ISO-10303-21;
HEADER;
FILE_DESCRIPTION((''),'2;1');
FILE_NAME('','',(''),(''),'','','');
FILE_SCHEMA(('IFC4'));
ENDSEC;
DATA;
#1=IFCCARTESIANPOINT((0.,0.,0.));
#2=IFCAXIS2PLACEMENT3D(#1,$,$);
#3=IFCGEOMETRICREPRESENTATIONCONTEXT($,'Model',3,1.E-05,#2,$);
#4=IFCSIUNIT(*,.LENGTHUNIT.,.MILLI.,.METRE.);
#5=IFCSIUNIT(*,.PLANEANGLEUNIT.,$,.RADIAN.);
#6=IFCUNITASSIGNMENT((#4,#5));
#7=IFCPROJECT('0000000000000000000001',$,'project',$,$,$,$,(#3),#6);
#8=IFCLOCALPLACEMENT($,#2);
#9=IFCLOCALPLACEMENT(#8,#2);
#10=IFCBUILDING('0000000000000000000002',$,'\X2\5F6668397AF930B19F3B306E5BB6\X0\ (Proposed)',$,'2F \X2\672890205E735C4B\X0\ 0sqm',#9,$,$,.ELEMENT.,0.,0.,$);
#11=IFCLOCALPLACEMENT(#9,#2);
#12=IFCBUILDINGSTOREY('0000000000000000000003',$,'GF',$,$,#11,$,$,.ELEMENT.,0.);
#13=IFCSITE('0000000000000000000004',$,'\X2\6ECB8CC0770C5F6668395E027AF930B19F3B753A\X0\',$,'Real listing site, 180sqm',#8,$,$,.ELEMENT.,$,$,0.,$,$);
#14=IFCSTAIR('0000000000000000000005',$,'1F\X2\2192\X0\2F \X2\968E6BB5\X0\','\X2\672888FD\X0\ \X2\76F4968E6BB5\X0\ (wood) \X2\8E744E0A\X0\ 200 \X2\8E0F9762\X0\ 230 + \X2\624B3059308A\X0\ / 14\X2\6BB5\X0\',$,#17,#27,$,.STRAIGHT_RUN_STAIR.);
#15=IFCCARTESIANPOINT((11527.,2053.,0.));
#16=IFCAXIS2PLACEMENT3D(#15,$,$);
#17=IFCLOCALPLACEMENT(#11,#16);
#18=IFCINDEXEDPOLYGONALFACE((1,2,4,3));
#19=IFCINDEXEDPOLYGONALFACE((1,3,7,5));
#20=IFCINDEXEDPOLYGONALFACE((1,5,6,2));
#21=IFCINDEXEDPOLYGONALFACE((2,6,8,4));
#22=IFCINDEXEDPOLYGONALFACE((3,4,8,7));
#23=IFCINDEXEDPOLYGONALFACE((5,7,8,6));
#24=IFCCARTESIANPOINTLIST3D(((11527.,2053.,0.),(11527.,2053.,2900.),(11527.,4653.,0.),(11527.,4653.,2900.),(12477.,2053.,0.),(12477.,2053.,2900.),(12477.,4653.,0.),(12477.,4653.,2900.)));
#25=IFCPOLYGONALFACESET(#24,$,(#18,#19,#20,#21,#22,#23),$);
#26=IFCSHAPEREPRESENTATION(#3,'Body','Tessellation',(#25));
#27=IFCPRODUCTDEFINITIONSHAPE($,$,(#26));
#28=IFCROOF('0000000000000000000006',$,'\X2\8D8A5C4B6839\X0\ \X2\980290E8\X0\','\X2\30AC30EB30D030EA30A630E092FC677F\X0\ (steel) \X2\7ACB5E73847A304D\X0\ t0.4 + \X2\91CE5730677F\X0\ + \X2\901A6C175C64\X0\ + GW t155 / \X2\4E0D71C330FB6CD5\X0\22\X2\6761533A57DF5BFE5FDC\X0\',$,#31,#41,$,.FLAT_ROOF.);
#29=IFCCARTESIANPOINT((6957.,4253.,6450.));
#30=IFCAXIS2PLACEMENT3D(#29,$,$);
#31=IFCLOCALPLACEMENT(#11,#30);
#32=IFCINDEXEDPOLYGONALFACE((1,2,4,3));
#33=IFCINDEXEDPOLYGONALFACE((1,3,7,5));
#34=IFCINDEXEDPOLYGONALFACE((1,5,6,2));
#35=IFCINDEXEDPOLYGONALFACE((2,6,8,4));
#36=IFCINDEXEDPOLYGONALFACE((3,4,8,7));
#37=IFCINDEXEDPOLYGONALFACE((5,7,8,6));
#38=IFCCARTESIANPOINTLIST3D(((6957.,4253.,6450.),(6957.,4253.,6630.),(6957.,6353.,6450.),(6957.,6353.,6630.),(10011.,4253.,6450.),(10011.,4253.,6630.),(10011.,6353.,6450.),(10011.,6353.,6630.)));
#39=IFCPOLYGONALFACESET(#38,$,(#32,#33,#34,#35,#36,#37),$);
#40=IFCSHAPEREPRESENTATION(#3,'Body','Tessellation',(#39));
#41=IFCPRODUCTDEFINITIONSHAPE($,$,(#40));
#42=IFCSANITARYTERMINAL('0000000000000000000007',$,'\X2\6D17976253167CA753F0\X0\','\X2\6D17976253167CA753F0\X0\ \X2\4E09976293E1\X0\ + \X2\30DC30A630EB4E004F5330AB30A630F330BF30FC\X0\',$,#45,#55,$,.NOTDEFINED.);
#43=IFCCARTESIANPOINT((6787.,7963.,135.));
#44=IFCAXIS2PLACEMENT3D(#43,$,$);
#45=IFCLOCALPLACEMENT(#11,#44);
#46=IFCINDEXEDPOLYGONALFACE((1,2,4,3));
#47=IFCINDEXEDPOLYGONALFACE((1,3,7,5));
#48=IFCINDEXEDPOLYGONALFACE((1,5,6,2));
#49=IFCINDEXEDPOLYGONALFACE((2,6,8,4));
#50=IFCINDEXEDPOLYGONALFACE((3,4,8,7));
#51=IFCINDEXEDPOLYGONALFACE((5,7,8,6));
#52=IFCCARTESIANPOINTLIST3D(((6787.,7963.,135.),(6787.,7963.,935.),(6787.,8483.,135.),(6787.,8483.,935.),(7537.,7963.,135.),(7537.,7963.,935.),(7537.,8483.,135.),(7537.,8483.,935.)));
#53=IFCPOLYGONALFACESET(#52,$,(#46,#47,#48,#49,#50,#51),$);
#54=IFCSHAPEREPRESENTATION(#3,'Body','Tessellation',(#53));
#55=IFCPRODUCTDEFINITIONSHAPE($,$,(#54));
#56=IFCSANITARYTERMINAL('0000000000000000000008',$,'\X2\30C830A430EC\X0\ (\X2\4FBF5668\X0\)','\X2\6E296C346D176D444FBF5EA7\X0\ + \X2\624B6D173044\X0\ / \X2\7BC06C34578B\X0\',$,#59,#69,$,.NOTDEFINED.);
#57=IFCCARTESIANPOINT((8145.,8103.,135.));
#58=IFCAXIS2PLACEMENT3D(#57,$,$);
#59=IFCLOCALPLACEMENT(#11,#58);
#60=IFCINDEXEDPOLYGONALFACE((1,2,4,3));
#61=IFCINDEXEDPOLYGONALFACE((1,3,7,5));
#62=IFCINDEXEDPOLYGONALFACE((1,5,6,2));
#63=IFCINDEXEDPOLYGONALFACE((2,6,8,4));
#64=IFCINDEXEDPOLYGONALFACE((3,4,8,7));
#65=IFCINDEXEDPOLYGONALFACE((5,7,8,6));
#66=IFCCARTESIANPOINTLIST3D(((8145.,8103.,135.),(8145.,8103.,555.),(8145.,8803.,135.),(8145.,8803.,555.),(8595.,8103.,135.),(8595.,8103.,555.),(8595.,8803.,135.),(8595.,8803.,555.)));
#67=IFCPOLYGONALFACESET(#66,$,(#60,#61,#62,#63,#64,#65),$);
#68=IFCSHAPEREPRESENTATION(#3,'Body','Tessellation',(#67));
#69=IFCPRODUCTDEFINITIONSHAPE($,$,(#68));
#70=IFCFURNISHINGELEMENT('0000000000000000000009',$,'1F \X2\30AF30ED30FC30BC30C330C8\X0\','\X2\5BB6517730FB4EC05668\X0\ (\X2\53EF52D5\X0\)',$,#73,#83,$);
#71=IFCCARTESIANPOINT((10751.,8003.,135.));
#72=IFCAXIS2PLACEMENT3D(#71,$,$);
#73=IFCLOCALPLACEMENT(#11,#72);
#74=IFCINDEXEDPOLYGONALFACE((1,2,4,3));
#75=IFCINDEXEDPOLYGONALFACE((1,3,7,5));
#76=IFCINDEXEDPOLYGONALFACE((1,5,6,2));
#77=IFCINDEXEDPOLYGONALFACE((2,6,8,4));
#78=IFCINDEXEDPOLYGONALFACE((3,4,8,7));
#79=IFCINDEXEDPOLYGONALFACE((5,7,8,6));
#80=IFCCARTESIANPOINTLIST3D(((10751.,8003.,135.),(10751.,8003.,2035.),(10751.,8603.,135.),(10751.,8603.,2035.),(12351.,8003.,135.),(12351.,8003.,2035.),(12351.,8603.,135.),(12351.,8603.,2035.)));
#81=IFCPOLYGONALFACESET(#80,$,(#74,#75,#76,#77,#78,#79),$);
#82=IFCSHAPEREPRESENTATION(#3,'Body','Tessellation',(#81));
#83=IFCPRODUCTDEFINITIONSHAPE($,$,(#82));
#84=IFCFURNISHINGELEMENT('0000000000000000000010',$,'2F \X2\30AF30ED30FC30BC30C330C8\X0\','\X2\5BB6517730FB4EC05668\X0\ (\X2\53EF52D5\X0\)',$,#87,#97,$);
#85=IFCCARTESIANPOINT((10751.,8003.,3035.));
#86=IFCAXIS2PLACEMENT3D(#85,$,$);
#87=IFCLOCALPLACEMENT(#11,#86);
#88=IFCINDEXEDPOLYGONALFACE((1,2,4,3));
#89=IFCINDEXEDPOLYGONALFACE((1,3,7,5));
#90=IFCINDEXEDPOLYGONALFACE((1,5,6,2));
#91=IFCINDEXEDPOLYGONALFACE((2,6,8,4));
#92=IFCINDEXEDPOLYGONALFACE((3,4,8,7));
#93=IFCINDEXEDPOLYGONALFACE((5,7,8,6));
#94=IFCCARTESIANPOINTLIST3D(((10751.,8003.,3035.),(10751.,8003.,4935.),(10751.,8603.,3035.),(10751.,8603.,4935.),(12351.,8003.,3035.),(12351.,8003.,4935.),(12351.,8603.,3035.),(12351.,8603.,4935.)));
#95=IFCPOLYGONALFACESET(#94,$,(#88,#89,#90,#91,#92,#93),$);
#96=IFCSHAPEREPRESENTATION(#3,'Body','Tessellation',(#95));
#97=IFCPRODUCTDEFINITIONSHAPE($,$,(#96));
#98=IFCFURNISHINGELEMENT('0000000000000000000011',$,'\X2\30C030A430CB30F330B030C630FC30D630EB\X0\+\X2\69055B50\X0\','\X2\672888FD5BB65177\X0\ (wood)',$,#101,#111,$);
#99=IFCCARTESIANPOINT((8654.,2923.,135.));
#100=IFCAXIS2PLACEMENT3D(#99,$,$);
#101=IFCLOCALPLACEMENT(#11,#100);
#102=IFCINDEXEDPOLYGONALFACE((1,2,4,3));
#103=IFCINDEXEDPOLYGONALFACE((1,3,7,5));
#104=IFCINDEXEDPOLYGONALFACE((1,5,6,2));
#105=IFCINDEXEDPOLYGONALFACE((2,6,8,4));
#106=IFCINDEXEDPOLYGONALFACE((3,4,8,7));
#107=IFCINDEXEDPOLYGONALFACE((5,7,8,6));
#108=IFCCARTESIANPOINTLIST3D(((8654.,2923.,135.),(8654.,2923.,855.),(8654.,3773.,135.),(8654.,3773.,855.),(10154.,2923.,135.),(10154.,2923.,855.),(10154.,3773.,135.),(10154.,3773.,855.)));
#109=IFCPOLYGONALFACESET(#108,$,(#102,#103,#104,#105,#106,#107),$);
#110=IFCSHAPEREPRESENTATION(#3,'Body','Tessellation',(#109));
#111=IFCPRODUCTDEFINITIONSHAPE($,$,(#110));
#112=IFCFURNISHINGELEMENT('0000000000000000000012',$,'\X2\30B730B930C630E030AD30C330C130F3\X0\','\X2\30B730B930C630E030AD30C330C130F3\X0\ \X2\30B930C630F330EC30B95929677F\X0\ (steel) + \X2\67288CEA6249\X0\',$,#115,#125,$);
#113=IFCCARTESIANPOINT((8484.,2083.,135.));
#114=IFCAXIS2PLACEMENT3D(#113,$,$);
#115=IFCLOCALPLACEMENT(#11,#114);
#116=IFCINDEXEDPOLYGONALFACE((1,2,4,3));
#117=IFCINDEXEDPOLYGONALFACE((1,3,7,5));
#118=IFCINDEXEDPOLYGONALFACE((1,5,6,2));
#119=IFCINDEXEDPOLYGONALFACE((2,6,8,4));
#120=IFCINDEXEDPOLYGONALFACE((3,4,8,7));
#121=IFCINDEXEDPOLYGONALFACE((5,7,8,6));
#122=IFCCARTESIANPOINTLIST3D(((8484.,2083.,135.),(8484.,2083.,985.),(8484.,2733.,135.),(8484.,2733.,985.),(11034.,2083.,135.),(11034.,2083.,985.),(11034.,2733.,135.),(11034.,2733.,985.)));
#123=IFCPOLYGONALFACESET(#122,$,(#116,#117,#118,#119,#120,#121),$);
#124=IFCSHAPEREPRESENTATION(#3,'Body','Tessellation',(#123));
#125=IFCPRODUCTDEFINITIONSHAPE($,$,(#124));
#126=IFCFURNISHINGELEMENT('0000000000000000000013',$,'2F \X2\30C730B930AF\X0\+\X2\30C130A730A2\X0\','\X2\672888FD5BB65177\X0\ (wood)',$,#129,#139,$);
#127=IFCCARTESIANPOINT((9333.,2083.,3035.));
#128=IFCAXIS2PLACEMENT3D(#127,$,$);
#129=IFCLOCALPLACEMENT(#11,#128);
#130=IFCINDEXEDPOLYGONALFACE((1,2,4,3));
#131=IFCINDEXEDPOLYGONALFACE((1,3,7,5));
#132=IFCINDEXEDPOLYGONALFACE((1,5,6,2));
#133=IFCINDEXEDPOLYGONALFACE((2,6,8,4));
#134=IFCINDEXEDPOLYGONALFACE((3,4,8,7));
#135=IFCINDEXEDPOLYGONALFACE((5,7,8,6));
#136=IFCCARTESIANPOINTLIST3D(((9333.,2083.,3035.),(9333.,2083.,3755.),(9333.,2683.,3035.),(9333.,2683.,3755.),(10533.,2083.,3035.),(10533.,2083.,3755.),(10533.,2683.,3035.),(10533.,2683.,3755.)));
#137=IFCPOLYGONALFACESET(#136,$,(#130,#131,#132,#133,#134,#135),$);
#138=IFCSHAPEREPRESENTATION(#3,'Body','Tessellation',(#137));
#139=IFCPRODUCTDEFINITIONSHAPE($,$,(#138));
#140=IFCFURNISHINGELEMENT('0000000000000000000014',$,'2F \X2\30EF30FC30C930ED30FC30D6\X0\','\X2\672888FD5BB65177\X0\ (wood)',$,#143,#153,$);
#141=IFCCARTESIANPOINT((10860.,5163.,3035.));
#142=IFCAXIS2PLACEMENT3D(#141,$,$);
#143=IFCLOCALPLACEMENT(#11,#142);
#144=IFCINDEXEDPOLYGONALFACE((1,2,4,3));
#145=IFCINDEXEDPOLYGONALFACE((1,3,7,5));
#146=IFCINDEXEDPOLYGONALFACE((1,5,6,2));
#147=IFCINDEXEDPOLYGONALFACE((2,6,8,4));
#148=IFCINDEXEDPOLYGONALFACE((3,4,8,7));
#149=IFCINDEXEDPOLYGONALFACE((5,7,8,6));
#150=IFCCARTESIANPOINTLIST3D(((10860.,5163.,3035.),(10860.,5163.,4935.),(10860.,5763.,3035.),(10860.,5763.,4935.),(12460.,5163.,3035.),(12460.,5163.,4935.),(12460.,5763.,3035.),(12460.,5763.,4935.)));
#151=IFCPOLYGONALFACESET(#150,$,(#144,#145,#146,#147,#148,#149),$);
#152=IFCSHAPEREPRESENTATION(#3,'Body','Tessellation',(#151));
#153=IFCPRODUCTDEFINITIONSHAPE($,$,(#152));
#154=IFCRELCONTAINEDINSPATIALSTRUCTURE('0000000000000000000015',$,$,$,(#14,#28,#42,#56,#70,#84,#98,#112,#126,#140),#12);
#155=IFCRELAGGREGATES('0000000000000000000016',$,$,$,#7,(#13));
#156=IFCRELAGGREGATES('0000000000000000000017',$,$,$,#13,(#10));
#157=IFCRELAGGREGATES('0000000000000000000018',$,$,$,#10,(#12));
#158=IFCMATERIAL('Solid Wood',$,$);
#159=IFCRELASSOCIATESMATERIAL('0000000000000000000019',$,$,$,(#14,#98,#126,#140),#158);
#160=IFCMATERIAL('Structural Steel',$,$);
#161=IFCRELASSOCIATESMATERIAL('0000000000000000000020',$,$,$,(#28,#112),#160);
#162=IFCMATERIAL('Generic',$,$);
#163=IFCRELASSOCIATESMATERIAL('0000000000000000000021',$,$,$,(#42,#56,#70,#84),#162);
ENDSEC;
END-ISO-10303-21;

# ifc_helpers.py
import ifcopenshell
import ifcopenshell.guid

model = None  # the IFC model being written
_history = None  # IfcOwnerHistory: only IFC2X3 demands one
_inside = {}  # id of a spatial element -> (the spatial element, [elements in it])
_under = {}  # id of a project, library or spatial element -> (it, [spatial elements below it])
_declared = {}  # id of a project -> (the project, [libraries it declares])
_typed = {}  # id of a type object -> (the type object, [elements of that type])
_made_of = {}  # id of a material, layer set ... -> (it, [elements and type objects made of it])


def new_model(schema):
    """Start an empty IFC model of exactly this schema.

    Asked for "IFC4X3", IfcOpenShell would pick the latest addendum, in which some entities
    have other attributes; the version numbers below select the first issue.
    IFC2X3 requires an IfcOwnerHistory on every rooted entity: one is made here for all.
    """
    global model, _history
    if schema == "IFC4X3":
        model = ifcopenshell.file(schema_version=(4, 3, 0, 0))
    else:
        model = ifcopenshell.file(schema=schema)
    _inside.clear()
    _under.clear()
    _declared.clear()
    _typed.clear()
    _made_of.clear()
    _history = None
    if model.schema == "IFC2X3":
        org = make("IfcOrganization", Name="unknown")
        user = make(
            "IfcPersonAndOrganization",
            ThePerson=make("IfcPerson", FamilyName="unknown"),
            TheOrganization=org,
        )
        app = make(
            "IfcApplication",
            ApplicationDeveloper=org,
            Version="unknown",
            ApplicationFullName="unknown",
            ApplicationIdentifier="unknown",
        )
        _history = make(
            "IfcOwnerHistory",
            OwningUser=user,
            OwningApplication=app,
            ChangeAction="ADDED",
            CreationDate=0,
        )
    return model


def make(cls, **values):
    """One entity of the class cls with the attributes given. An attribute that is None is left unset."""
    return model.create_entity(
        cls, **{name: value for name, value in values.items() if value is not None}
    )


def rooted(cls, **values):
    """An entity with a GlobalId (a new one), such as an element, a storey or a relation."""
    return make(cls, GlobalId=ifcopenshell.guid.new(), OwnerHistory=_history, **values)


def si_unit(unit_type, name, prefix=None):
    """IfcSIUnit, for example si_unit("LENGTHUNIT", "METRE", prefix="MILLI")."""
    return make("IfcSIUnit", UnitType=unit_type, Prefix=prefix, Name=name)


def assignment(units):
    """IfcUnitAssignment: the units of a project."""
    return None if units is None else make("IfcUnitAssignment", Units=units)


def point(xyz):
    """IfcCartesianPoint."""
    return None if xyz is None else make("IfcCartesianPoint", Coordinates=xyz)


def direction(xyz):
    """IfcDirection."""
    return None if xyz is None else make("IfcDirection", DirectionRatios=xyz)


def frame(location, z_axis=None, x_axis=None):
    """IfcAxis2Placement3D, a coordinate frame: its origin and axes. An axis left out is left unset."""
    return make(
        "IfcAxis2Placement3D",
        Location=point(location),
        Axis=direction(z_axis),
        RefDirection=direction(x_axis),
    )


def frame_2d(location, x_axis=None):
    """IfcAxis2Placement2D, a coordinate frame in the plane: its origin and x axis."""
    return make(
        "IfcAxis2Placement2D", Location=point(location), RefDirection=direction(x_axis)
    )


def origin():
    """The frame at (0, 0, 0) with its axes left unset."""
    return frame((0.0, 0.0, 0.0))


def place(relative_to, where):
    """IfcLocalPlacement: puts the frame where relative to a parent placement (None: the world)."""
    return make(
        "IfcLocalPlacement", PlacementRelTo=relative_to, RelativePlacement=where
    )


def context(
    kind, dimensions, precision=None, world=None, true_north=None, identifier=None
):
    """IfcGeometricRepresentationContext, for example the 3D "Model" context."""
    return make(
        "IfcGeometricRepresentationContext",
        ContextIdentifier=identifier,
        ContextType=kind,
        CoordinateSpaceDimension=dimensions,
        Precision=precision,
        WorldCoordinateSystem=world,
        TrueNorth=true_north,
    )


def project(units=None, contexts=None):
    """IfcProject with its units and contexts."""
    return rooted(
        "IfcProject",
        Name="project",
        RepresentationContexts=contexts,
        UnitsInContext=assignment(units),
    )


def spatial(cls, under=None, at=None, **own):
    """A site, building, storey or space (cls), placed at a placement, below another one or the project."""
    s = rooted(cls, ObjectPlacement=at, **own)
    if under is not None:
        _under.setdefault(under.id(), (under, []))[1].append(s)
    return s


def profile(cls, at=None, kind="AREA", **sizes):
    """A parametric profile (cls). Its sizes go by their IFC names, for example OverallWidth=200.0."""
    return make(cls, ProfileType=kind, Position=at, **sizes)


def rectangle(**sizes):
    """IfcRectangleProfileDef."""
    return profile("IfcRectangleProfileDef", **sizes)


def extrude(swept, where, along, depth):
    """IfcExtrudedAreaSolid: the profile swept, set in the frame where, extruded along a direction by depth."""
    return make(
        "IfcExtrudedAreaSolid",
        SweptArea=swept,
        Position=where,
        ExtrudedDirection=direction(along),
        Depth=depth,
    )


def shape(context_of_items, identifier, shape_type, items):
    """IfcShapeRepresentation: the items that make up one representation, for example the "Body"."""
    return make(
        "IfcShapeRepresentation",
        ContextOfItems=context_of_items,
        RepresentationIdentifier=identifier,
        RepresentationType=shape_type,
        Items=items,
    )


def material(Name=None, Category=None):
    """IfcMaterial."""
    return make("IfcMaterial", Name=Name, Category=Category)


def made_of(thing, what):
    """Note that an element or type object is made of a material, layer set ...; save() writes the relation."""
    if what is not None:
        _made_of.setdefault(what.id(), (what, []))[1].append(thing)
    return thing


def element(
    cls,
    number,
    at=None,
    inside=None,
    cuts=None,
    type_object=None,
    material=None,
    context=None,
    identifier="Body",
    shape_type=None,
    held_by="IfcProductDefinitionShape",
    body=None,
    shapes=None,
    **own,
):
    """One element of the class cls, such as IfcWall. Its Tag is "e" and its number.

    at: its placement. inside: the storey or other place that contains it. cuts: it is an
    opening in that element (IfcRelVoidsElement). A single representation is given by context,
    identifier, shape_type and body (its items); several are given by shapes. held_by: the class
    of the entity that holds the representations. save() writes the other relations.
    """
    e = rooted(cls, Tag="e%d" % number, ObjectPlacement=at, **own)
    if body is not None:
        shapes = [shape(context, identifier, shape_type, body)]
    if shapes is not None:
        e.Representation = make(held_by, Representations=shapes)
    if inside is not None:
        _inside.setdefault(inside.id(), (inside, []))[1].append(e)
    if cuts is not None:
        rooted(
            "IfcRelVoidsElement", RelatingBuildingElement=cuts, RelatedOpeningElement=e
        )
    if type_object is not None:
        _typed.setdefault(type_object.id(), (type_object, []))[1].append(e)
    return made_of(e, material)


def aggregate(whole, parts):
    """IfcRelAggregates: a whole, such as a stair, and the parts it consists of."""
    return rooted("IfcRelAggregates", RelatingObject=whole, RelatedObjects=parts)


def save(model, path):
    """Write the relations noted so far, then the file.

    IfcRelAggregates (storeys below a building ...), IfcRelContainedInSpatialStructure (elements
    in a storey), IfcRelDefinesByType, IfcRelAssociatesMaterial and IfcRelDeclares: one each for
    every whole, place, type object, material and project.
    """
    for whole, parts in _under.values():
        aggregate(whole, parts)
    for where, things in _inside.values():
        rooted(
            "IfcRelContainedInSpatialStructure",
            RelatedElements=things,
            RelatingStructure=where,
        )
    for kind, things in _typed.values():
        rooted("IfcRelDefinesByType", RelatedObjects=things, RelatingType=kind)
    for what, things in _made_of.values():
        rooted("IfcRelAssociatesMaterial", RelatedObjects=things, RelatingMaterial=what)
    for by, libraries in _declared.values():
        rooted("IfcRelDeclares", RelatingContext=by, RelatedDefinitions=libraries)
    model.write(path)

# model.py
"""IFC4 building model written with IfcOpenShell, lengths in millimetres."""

from ifc_helpers import new_model, si_unit, frame, frame_2d, origin, place, context, project, spatial, rectangle, extrude, material, element, save


model = new_model("IFC4")

# Units and contexts
model_context = context("Model", 3, precision=1e-05, world=origin())
ifc_project = project(units=[si_unit("LENGTHUNIT", "METRE", prefix="MILLI"), si_unit("PLANEANGLEUNIT", "RADIAN")], contexts=[model_context])

# Site, building, storey
site_placement = place(None, origin())
site = spatial("IfcSite", under=ifc_project, at=site_placement, Name="滋賀県彦根市竹ケ鼻町", ObjectType="Real listing site, 180sqm", CompositionType="ELEMENT", RefElevation=0.0)
building_placement = place(site_placement, origin())
building = spatial("IfcBuilding", under=site, at=building_placement, Name="彦根竹ケ鼻の家 (Proposed)", ObjectType="2F 木造平屋 0sqm", CompositionType="ELEMENT", ElevationOfRefHeight=0.0, ElevationOfTerrain=0.0)
storey_placement = place(building_placement, origin())
storey = spatial("IfcBuildingStorey", under=building, at=storey_placement, Name="GF", CompositionType="ELEMENT", Elevation=0.0)

# Shared definitions
ifc_material_1 = material(Name="Solid Wood")

# Stair
stair_placement = place(storey_placement, frame((11527.0, 2053.0, 0.0)))
element("IfcStair", 1, at=stair_placement, inside=storey, material=ifc_material_1, Name="1F→2F 階段", Description="木製 直階段 (wood) 蹴上 200 踏面 230 + 手すり / 14段", PredefinedType="STRAIGHT_RUN_STAIR", context=model_context, shape_type="SweptSolid", body=[
    extrude(rectangle(XDim=950.0, YDim=2600.0, at=frame_2d((475.0, 1300.0))), frame((11527.0, 2053.0, 0.0)), (0.0, 0.0, 1.0), 2900.0),
])

# Roof
ifc_material_2 = material(Name="Structural Steel")
roof_placement = place(storey_placement, frame((6957.0, 4253.0, 6450.0)))
element("IfcRoof", 2, at=roof_placement, inside=storey, material=ifc_material_2, Name="越屋根 頂部", Description="ガルバリウム鋼板 (steel) 立平葺き t0.4 + 野地板 + 通気層 + GW t155 / 不燃・法22条区域対応", PredefinedType="FLAT_ROOF", context=model_context, shape_type="SweptSolid", body=[
    extrude(rectangle(XDim=3054.0, YDim=2100.0, at=frame_2d((1527.0, 1050.0))), frame((6957.0, 4253.0, 6450.0)), (0.0, 0.0, 1.0), 180.0),
])

# Sanitary terminals
ifc_material_3 = material(Name="Generic")
sanitary_terminal_1_placement = place(storey_placement, frame((6787.0, 7963.0, 135.0)))
element("IfcSanitaryTerminal", 3, at=sanitary_terminal_1_placement, inside=storey, material=ifc_material_3, Name="洗面化粧台", Description="洗面化粧台 三面鏡 + ボウル一体カウンター", PredefinedType="NOTDEFINED", context=model_context, shape_type="SweptSolid", body=[
    extrude(rectangle(XDim=750.0, YDim=520.0, at=frame_2d((375.0, 260.0))), frame((6787.0, 7963.0, 135.0)), (0.0, 0.0, 1.0), 800.0),
])
sanitary_terminal_2_placement = place(storey_placement, frame((8145.0, 8103.0, 135.0)))
element("IfcSanitaryTerminal", 4, at=sanitary_terminal_2_placement, inside=storey, material=ifc_material_3, Name="トイレ (便器)", Description="温水洗浄便座 + 手洗い / 節水型", PredefinedType="NOTDEFINED", context=model_context, shape_type="SweptSolid", body=[
    extrude(rectangle(XDim=450.0, YDim=700.0, at=frame_2d((225.0, 350.0))), frame((8145.0, 8103.0, 135.0)), (0.0, 0.0, 1.0), 420.0),
])

# Furnishing elements
furnishing_1_placement = place(storey_placement, frame((10751.0, 8003.0, 135.0)))
element("IfcFurnishingElement", 5, at=furnishing_1_placement, inside=storey, material=ifc_material_3, Name="1F クローゼット", Description="家具・什器 (可動)", context=model_context, shape_type="SweptSolid", body=[
    extrude(rectangle(XDim=1600.0, YDim=600.0, at=frame_2d((800.0, 300.0))), frame((10751.0, 8003.0, 135.0)), (0.0, 0.0, 1.0), 1900.0),
])
furnishing_2_placement = place(storey_placement, frame((10751.0, 8003.0, 3035.0)))
element("IfcFurnishingElement", 6, at=furnishing_2_placement, inside=storey, material=ifc_material_3, Name="2F クローゼット", Description="家具・什器 (可動)", context=model_context, shape_type="SweptSolid", body=[
    extrude(rectangle(XDim=1600.0, YDim=600.0, at=frame_2d((800.0, 300.0))), frame((10751.0, 8003.0, 3035.0)), (0.0, 0.0, 1.0), 1900.0),
])
furnishing_3_placement = place(storey_placement, frame((8654.0, 2923.0, 135.0)))
element("IfcFurnishingElement", 7, at=furnishing_3_placement, inside=storey, material=ifc_material_1, Name="ダイニングテーブル+椅子", Description="木製家具 (wood)", context=model_context, shape_type="SweptSolid", body=[
    extrude(rectangle(XDim=1500.0, YDim=850.0, at=frame_2d((750.0, 425.0))), frame((8654.0, 2923.0, 135.0)), (0.0, 0.0, 1.0), 720.0),
])
furnishing_4_placement = place(storey_placement, frame((8484.0, 2083.0, 135.0)))
element("IfcFurnishingElement", 8, at=furnishing_4_placement, inside=storey, material=ifc_material_2, Name="システムキッチン", Description="システムキッチン ステンレス天板 (steel) + 木質扉", context=model_context, shape_type="SweptSolid", body=[
    extrude(rectangle(XDim=2550.0, YDim=650.0, at=frame_2d((1275.0, 325.0))), frame((8484.0, 2083.0, 135.0)), (0.0, 0.0, 1.0), 850.0),
])
furnishing_5_placement = place(storey_placement, frame((9333.0, 2083.0, 3035.0)))
element("IfcFurnishingElement", 9, at=furnishing_5_placement, inside=storey, material=ifc_material_1, Name="2F デスク+チェア", Description="木製家具 (wood)", context=model_context, shape_type="SweptSolid", body=[
    extrude(rectangle(XDim=1200.0, YDim=600.0, at=frame_2d((600.0, 300.0))), frame((9333.0, 2083.0, 3035.0)), (0.0, 0.0, 1.0), 720.0),
])
furnishing_6_placement = place(storey_placement, frame((10860.0, 5163.0, 3035.0)))
element("IfcFurnishingElement", 10, at=furnishing_6_placement, inside=storey, material=ifc_material_1, Name="2F ワードローブ", Description="木製家具 (wood)", context=model_context, shape_type="SweptSolid", body=[
    extrude(rectangle(XDim=1600.0, YDim=600.0, at=frame_2d((800.0, 300.0))), frame((10860.0, 5163.0, 3035.0)), (0.0, 0.0, 1.0), 1900.0),
])

save(model, "model.ifc")
